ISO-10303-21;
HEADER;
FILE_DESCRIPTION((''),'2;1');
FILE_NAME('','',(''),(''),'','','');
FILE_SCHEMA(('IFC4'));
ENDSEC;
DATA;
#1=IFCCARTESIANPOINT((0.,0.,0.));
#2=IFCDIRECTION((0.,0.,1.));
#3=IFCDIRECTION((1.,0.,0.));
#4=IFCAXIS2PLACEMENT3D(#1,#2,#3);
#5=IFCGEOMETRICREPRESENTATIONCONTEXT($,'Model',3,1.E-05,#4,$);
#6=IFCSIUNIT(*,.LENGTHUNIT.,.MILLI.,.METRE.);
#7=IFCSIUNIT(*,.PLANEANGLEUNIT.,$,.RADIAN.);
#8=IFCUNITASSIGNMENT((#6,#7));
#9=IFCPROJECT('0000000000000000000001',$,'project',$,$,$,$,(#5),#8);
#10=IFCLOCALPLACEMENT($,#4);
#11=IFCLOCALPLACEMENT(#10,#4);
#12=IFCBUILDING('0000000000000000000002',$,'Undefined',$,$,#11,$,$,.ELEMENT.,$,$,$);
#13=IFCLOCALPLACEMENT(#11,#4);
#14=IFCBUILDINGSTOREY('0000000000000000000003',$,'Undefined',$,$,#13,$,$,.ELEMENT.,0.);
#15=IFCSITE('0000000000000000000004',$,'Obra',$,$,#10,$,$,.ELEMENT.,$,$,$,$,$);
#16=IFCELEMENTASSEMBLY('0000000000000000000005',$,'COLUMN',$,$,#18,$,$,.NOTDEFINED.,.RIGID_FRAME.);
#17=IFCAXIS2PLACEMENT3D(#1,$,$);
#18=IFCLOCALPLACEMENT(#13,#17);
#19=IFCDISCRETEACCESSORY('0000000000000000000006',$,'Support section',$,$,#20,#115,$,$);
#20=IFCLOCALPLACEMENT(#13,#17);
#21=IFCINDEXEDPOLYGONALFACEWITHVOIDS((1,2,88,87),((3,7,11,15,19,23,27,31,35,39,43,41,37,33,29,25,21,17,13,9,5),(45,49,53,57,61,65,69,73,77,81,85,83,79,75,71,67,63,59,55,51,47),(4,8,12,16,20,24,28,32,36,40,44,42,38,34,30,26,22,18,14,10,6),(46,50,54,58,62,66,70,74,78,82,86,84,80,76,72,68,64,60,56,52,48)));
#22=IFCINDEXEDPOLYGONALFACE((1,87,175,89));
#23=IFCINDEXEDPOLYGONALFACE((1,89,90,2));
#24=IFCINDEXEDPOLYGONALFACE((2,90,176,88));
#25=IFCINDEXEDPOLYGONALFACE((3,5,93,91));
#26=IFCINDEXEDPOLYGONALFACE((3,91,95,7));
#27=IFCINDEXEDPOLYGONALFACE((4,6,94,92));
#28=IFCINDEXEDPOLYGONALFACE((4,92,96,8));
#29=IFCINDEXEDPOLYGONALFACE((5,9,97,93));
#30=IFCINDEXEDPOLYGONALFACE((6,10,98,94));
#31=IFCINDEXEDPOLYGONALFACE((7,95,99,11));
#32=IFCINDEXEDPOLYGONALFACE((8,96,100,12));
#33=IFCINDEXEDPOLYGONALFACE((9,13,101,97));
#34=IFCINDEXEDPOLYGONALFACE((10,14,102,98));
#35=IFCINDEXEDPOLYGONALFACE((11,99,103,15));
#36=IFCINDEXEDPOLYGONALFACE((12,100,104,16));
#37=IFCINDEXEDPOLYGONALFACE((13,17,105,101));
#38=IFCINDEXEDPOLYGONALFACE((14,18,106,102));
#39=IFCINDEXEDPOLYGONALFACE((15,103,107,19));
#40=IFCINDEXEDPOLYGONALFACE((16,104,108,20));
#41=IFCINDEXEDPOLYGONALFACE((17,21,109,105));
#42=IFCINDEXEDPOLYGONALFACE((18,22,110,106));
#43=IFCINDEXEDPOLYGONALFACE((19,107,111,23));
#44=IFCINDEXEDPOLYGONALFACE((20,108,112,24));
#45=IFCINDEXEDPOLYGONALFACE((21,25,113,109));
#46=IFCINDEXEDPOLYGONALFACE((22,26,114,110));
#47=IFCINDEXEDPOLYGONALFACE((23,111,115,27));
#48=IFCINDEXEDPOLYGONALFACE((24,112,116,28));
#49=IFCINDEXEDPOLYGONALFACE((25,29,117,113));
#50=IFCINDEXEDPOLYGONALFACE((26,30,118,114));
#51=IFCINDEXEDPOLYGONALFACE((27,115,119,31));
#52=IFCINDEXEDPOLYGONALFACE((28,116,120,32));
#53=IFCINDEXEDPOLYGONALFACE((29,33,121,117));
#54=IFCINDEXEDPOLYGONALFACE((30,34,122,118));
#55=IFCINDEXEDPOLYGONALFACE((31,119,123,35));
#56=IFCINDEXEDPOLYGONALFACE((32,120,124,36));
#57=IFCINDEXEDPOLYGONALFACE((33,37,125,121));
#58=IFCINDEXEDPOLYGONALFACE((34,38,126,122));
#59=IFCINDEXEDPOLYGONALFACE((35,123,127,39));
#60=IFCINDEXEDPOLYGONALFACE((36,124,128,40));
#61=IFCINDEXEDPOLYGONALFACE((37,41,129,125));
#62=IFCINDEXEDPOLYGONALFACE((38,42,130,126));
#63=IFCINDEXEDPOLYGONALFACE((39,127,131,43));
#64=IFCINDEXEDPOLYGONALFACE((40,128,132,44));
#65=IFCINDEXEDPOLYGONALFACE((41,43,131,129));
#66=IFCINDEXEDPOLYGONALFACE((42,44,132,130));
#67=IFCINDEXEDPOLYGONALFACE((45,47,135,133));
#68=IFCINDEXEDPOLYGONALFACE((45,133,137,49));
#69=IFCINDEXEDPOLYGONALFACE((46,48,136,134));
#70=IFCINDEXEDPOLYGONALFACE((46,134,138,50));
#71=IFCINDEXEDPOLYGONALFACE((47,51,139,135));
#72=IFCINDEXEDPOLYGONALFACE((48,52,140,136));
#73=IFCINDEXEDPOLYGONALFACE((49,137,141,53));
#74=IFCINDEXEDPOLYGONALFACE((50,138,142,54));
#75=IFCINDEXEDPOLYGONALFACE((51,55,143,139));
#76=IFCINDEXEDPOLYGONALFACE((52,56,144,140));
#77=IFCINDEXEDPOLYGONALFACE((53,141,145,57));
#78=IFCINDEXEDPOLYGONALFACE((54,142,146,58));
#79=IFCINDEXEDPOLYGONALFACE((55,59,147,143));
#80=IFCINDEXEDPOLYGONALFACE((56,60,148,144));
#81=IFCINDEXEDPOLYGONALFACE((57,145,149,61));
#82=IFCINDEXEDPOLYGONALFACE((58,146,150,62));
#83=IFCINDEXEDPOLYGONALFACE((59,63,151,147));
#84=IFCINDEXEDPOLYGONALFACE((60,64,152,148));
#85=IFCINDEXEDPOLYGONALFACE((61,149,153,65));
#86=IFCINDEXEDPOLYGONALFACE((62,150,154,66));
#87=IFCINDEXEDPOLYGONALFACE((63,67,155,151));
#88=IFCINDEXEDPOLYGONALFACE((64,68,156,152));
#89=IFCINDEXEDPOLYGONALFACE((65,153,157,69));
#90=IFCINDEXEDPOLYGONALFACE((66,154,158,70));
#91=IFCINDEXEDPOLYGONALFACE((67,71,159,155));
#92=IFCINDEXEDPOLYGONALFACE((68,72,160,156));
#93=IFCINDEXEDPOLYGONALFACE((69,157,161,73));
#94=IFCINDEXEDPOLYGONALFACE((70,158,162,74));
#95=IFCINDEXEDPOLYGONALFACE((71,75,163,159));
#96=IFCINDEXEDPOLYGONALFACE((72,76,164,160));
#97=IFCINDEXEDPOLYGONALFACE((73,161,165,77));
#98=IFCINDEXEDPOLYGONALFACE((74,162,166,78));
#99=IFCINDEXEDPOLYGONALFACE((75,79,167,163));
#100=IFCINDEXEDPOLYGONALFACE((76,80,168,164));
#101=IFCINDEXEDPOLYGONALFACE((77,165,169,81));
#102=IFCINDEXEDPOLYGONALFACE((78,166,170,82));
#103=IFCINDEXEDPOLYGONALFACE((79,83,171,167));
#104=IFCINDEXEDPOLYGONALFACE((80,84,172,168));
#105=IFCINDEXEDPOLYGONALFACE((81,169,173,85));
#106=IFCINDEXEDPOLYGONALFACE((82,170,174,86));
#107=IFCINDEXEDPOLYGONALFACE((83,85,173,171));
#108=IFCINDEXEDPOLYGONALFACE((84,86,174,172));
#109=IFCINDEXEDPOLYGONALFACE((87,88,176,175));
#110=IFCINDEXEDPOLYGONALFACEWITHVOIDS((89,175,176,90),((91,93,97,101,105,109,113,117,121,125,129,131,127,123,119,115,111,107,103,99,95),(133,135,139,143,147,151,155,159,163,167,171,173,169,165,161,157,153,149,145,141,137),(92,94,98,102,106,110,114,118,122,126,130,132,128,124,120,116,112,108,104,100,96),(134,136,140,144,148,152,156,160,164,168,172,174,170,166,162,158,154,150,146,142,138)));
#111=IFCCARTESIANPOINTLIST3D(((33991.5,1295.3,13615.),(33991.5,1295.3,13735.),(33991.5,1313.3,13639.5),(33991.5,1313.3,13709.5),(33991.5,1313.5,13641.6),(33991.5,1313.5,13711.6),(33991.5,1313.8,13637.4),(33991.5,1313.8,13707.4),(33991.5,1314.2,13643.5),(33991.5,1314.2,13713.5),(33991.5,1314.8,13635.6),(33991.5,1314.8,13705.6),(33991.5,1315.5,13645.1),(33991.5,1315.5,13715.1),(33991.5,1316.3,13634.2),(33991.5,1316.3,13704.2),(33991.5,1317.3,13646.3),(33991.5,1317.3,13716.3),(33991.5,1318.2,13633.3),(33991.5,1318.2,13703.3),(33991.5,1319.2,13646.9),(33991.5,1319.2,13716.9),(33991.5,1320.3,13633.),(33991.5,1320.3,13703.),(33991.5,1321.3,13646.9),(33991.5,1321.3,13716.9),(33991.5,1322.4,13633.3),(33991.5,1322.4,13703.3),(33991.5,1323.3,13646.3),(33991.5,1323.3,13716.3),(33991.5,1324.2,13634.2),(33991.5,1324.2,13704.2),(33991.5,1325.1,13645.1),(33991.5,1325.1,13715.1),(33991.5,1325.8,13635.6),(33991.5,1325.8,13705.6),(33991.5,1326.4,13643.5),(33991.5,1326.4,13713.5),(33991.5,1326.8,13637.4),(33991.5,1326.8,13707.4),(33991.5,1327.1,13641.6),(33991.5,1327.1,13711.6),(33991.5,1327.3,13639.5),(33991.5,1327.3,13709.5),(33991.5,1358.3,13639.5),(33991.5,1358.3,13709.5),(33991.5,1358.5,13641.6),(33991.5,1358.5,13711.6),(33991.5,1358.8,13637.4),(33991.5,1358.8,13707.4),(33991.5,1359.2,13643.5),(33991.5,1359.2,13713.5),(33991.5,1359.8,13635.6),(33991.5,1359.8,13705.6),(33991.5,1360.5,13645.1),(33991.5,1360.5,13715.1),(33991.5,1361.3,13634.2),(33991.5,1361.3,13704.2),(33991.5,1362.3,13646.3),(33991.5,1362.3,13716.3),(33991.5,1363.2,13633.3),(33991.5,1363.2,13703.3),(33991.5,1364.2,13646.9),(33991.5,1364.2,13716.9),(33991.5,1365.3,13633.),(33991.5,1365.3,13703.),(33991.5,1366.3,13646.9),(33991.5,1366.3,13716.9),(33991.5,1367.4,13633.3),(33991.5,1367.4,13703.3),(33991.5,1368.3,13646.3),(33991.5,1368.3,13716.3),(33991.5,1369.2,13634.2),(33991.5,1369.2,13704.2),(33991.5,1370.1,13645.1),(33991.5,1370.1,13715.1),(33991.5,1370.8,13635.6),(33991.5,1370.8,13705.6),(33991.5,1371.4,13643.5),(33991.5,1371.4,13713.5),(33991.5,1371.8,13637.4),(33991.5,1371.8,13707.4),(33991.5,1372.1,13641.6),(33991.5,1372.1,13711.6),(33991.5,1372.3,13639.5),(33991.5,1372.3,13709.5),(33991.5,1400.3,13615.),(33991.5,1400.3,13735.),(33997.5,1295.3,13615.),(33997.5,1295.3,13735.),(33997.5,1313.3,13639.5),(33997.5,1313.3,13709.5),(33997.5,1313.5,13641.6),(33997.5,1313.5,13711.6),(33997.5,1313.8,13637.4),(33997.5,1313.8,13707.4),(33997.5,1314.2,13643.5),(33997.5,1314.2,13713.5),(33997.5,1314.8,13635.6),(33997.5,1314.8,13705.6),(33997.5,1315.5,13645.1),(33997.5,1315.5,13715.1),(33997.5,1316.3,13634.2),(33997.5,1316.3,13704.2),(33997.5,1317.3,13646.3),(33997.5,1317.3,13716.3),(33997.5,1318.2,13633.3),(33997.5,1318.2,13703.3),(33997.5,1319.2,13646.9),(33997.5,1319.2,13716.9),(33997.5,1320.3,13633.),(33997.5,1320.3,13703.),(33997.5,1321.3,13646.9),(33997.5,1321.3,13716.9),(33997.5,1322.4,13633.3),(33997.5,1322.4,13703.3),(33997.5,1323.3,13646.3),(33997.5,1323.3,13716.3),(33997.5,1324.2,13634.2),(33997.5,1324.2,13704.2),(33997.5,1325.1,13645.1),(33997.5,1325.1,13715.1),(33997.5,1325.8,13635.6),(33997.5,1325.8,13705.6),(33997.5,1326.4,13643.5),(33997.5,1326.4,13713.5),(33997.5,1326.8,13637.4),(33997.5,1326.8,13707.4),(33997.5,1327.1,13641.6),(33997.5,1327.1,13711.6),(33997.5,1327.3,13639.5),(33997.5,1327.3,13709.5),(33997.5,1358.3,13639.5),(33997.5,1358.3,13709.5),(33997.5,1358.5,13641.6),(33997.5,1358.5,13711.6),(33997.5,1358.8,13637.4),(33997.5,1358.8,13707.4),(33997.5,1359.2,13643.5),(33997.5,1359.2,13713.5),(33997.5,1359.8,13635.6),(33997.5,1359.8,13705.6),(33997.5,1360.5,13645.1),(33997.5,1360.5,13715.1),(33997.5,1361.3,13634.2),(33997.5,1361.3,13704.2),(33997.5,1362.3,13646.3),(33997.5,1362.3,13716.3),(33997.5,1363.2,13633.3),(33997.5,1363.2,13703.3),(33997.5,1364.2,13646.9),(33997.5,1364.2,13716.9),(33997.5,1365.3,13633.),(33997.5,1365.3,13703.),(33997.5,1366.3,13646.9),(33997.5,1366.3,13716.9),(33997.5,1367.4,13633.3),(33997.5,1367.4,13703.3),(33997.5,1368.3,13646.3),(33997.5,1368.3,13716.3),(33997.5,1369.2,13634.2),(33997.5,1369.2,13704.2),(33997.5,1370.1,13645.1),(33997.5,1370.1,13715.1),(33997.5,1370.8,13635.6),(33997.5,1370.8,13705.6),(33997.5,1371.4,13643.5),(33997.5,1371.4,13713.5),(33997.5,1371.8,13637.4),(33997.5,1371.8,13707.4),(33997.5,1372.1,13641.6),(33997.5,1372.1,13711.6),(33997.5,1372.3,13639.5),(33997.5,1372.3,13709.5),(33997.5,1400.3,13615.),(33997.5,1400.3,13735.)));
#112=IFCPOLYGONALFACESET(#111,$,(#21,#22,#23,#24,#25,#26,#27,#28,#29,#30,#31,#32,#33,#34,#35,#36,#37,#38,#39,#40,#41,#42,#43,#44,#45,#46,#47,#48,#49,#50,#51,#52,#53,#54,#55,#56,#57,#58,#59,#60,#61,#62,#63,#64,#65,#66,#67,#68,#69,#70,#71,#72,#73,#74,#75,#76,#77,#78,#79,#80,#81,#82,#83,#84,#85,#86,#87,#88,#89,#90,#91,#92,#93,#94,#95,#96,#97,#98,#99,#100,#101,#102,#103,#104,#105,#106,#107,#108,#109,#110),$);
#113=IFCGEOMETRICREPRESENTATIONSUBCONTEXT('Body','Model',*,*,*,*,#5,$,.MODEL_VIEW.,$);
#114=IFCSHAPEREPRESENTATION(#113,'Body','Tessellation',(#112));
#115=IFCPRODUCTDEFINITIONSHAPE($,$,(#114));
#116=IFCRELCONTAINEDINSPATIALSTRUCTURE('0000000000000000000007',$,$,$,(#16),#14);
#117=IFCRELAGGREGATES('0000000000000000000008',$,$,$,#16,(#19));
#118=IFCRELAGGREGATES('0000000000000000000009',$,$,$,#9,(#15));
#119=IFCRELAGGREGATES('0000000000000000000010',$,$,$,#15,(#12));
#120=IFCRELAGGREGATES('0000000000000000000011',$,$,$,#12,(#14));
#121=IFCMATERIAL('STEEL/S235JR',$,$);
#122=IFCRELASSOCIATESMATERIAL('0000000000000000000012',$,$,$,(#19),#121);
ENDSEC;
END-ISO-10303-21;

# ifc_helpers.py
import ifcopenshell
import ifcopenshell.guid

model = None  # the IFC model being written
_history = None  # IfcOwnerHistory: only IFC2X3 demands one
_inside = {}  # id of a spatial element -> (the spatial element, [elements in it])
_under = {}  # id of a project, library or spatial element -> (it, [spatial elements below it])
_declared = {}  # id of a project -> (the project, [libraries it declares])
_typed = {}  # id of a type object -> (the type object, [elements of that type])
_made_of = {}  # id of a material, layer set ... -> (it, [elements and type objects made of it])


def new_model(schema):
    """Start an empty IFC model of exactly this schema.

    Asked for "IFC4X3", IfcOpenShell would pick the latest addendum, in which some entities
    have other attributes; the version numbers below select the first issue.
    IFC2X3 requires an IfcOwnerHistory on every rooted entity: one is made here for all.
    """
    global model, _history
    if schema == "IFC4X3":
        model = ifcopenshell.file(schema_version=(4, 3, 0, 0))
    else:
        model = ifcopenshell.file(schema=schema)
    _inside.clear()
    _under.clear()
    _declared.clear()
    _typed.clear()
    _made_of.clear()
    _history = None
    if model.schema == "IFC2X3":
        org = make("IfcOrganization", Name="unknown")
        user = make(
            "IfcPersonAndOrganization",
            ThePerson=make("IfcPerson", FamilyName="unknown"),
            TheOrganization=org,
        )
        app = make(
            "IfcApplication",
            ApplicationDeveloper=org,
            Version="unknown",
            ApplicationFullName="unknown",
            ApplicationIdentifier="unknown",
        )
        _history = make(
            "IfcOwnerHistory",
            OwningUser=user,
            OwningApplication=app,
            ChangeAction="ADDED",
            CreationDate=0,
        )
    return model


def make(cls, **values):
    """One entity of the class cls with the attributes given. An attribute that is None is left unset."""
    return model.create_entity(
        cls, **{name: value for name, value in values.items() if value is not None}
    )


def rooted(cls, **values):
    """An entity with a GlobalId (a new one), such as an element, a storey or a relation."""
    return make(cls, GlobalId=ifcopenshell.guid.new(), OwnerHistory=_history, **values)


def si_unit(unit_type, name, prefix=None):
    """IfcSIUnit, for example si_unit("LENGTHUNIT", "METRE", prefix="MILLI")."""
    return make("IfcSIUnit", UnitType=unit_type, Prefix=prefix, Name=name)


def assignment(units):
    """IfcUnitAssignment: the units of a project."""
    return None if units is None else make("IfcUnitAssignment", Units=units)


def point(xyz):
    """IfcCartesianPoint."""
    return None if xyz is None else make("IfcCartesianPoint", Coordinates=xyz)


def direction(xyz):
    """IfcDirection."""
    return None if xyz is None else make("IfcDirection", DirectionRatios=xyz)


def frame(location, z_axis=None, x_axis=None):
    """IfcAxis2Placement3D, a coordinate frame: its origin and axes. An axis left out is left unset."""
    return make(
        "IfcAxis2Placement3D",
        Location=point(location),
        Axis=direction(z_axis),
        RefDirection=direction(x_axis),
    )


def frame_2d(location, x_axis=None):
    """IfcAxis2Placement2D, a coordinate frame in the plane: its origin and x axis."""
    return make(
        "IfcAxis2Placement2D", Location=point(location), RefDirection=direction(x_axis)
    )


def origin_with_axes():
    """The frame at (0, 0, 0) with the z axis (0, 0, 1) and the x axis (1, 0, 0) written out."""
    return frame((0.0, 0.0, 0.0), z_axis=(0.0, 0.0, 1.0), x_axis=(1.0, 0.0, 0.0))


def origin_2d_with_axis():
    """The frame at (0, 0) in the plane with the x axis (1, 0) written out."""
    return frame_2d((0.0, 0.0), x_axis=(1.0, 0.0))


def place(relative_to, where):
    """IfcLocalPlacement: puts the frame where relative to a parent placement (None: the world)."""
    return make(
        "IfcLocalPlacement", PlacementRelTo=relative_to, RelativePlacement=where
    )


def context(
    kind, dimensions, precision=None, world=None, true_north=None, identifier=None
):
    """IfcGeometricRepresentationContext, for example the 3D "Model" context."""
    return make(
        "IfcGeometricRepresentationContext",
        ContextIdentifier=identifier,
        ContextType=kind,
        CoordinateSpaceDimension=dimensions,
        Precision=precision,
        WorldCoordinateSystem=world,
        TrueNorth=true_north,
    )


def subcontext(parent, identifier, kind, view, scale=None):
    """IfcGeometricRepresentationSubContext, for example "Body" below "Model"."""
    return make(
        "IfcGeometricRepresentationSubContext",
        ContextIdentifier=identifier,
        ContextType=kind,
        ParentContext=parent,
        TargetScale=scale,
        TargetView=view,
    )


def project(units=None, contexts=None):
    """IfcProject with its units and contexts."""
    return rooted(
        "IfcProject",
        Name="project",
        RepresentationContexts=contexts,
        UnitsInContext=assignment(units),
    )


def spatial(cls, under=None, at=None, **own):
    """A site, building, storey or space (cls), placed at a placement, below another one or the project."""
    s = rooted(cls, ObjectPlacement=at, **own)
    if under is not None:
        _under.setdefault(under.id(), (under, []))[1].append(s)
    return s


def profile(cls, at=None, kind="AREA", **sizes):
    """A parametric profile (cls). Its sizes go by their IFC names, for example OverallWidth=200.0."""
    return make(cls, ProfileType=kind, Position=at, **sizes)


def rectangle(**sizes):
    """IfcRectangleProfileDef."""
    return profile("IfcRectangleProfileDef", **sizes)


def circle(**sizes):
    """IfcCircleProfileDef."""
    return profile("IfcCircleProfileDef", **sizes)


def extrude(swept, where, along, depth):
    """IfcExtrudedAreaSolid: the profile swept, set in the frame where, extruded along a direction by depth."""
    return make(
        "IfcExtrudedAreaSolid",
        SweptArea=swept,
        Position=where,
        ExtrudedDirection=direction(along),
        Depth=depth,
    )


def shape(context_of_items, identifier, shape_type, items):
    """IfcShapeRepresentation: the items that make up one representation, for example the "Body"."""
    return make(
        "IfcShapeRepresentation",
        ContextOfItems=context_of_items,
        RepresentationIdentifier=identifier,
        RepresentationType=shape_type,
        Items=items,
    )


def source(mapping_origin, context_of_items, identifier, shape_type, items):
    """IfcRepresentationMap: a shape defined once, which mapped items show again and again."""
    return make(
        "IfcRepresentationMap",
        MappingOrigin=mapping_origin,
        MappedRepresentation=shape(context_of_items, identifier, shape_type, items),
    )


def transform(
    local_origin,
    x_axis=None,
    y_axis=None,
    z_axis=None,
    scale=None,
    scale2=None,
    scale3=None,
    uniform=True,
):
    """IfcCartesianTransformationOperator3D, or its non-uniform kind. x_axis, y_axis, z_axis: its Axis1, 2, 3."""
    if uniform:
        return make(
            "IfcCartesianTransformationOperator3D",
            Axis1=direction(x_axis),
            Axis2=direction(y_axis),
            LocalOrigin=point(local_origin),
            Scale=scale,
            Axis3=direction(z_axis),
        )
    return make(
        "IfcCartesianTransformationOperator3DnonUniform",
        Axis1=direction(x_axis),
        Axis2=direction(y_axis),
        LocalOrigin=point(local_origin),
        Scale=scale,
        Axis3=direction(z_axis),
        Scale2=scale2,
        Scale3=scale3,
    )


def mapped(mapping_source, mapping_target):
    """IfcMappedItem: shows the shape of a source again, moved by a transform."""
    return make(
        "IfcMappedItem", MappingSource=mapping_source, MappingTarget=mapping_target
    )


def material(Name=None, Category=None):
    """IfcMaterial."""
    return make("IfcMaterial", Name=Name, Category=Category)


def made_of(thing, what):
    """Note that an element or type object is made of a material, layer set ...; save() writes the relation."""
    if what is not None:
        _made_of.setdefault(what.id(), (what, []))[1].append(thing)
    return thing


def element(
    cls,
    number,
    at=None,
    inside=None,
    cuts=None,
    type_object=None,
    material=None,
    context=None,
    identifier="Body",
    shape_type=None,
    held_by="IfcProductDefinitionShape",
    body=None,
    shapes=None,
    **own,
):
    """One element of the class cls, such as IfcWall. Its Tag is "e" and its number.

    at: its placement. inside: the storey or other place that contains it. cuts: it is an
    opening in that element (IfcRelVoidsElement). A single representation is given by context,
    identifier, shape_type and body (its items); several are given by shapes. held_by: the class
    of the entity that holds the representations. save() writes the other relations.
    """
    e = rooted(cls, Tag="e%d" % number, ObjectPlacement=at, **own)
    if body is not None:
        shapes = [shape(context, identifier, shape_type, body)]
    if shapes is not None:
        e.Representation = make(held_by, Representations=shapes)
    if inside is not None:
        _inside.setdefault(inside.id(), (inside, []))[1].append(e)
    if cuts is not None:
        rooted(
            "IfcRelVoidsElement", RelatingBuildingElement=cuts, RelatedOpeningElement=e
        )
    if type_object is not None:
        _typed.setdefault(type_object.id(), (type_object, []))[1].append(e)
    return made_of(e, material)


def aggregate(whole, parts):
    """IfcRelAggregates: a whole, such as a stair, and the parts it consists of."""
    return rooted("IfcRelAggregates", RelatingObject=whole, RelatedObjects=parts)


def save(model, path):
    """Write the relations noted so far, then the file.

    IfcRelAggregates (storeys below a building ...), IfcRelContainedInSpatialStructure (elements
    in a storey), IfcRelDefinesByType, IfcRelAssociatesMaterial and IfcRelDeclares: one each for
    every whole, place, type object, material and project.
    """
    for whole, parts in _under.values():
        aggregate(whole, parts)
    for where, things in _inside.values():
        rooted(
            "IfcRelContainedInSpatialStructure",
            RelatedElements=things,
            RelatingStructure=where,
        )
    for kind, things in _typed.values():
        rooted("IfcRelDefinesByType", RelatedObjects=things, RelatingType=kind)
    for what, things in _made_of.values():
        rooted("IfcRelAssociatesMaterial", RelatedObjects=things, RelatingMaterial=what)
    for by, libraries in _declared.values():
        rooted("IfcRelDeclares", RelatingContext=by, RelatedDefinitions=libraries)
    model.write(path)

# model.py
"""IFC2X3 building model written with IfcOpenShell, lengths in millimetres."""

from ifc_helpers import new_model, si_unit, frame, origin_with_axes, origin_2d_with_axis, place, context, subcontext, project, spatial, rectangle, circle, extrude, source, transform, mapped, material, element, aggregate, save


model = new_model("IFC2X3")

# Units and contexts
model_context = context("Model", 3, precision=1e-05, world=origin_with_axes())
body_context = subcontext(model_context, "Body", "Model", "MODEL_VIEW")
ifc_project = project(units=[si_unit("LENGTHUNIT", "METRE", prefix="MILLI"), si_unit("PLANEANGLEUNIT", "RADIAN")], contexts=[model_context])

# Site, building, storey
site_placement = place(None, origin_with_axes())
site = spatial("IfcSite", under=ifc_project, at=site_placement, Name="Obra", CompositionType="ELEMENT")
building_placement = place(site_placement, origin_with_axes())
building = spatial("IfcBuilding", under=site, at=building_placement, Name="Undefined", CompositionType="ELEMENT")
storey_placement = place(building_placement, origin_with_axes())
storey = spatial("IfcBuildingStorey", under=building, at=storey_placement, Name="Undefined", CompositionType="ELEMENT", Elevation=0.0)

# Element assembly
assembly_1_placement = place(storey_placement, origin_with_axes())
assembly_1 = element("IfcElementAssembly", 1, at=assembly_1_placement, inside=storey, Name="COLUMN", AssemblyPlace="NOTDEFINED", PredefinedType="RIGID_FRAME")
ifc_material_1 = material(Name="STEEL/S235JR")

# Shared definitions
shared_shape_1 = source(origin_with_axes(), body_context, "Body", "SweptSolid", [
    extrude(circle(Radius=7.0, at=origin_2d_with_axis()), frame((0.0, -8.6, 0.0), z_axis=(0.0, 1.0, 0.0), x_axis=(1.0, 0.0, 0.0)), (0.0, 0.0, 1.0), 6.2),
])

# Discrete accessory, opening
discrete_accessory_1_placement = place(assembly_1_placement, frame((33994.5, 1347.8, 13615.0), z_axis=(0.0, 0.0, 1.0), x_axis=(0.0, 1.0, 0.0)))
discrete_accessory_1 = element("IfcDiscreteAccessory", 2, at=discrete_accessory_1_placement, material=ifc_material_1, Name="Support section", context=body_context, shape_type="SweptSolid", body=[
    extrude(rectangle(XDim=6.0, YDim=105.0, at=origin_2d_with_axis()), frame((0.0, 0.0, 120.0), z_axis=(0.0, 0.0, -1.0), x_axis=(0.0, 1.0, 0.0)), (0.0, 0.0, 1.0), 120.0),
])
opening_1_placement = place(assembly_1_placement, frame((34000.0, 1390.3, 13755.0), z_axis=(0.0, -1.0, 0.0), x_axis=(0.0, 0.0, -1.0)))
element("IfcOpeningElement", 3, at=opening_1_placement, cuts=discrete_accessory_1, ObjectType="Opening", context=body_context, shape_type="MappedRepresentation", body=[
    mapped(shared_shape_1, transform((45.0, 0.0, 25.0))),
    mapped(shared_shape_1, transform((45.0, 0.0, 70.0))),
    mapped(shared_shape_1, transform((115.0, 0.0, 25.0))),
    mapped(shared_shape_1, transform((115.0, 0.0, 70.0))),
])
aggregate(assembly_1, [discrete_accessory_1])

save(model, "model.ifc")
